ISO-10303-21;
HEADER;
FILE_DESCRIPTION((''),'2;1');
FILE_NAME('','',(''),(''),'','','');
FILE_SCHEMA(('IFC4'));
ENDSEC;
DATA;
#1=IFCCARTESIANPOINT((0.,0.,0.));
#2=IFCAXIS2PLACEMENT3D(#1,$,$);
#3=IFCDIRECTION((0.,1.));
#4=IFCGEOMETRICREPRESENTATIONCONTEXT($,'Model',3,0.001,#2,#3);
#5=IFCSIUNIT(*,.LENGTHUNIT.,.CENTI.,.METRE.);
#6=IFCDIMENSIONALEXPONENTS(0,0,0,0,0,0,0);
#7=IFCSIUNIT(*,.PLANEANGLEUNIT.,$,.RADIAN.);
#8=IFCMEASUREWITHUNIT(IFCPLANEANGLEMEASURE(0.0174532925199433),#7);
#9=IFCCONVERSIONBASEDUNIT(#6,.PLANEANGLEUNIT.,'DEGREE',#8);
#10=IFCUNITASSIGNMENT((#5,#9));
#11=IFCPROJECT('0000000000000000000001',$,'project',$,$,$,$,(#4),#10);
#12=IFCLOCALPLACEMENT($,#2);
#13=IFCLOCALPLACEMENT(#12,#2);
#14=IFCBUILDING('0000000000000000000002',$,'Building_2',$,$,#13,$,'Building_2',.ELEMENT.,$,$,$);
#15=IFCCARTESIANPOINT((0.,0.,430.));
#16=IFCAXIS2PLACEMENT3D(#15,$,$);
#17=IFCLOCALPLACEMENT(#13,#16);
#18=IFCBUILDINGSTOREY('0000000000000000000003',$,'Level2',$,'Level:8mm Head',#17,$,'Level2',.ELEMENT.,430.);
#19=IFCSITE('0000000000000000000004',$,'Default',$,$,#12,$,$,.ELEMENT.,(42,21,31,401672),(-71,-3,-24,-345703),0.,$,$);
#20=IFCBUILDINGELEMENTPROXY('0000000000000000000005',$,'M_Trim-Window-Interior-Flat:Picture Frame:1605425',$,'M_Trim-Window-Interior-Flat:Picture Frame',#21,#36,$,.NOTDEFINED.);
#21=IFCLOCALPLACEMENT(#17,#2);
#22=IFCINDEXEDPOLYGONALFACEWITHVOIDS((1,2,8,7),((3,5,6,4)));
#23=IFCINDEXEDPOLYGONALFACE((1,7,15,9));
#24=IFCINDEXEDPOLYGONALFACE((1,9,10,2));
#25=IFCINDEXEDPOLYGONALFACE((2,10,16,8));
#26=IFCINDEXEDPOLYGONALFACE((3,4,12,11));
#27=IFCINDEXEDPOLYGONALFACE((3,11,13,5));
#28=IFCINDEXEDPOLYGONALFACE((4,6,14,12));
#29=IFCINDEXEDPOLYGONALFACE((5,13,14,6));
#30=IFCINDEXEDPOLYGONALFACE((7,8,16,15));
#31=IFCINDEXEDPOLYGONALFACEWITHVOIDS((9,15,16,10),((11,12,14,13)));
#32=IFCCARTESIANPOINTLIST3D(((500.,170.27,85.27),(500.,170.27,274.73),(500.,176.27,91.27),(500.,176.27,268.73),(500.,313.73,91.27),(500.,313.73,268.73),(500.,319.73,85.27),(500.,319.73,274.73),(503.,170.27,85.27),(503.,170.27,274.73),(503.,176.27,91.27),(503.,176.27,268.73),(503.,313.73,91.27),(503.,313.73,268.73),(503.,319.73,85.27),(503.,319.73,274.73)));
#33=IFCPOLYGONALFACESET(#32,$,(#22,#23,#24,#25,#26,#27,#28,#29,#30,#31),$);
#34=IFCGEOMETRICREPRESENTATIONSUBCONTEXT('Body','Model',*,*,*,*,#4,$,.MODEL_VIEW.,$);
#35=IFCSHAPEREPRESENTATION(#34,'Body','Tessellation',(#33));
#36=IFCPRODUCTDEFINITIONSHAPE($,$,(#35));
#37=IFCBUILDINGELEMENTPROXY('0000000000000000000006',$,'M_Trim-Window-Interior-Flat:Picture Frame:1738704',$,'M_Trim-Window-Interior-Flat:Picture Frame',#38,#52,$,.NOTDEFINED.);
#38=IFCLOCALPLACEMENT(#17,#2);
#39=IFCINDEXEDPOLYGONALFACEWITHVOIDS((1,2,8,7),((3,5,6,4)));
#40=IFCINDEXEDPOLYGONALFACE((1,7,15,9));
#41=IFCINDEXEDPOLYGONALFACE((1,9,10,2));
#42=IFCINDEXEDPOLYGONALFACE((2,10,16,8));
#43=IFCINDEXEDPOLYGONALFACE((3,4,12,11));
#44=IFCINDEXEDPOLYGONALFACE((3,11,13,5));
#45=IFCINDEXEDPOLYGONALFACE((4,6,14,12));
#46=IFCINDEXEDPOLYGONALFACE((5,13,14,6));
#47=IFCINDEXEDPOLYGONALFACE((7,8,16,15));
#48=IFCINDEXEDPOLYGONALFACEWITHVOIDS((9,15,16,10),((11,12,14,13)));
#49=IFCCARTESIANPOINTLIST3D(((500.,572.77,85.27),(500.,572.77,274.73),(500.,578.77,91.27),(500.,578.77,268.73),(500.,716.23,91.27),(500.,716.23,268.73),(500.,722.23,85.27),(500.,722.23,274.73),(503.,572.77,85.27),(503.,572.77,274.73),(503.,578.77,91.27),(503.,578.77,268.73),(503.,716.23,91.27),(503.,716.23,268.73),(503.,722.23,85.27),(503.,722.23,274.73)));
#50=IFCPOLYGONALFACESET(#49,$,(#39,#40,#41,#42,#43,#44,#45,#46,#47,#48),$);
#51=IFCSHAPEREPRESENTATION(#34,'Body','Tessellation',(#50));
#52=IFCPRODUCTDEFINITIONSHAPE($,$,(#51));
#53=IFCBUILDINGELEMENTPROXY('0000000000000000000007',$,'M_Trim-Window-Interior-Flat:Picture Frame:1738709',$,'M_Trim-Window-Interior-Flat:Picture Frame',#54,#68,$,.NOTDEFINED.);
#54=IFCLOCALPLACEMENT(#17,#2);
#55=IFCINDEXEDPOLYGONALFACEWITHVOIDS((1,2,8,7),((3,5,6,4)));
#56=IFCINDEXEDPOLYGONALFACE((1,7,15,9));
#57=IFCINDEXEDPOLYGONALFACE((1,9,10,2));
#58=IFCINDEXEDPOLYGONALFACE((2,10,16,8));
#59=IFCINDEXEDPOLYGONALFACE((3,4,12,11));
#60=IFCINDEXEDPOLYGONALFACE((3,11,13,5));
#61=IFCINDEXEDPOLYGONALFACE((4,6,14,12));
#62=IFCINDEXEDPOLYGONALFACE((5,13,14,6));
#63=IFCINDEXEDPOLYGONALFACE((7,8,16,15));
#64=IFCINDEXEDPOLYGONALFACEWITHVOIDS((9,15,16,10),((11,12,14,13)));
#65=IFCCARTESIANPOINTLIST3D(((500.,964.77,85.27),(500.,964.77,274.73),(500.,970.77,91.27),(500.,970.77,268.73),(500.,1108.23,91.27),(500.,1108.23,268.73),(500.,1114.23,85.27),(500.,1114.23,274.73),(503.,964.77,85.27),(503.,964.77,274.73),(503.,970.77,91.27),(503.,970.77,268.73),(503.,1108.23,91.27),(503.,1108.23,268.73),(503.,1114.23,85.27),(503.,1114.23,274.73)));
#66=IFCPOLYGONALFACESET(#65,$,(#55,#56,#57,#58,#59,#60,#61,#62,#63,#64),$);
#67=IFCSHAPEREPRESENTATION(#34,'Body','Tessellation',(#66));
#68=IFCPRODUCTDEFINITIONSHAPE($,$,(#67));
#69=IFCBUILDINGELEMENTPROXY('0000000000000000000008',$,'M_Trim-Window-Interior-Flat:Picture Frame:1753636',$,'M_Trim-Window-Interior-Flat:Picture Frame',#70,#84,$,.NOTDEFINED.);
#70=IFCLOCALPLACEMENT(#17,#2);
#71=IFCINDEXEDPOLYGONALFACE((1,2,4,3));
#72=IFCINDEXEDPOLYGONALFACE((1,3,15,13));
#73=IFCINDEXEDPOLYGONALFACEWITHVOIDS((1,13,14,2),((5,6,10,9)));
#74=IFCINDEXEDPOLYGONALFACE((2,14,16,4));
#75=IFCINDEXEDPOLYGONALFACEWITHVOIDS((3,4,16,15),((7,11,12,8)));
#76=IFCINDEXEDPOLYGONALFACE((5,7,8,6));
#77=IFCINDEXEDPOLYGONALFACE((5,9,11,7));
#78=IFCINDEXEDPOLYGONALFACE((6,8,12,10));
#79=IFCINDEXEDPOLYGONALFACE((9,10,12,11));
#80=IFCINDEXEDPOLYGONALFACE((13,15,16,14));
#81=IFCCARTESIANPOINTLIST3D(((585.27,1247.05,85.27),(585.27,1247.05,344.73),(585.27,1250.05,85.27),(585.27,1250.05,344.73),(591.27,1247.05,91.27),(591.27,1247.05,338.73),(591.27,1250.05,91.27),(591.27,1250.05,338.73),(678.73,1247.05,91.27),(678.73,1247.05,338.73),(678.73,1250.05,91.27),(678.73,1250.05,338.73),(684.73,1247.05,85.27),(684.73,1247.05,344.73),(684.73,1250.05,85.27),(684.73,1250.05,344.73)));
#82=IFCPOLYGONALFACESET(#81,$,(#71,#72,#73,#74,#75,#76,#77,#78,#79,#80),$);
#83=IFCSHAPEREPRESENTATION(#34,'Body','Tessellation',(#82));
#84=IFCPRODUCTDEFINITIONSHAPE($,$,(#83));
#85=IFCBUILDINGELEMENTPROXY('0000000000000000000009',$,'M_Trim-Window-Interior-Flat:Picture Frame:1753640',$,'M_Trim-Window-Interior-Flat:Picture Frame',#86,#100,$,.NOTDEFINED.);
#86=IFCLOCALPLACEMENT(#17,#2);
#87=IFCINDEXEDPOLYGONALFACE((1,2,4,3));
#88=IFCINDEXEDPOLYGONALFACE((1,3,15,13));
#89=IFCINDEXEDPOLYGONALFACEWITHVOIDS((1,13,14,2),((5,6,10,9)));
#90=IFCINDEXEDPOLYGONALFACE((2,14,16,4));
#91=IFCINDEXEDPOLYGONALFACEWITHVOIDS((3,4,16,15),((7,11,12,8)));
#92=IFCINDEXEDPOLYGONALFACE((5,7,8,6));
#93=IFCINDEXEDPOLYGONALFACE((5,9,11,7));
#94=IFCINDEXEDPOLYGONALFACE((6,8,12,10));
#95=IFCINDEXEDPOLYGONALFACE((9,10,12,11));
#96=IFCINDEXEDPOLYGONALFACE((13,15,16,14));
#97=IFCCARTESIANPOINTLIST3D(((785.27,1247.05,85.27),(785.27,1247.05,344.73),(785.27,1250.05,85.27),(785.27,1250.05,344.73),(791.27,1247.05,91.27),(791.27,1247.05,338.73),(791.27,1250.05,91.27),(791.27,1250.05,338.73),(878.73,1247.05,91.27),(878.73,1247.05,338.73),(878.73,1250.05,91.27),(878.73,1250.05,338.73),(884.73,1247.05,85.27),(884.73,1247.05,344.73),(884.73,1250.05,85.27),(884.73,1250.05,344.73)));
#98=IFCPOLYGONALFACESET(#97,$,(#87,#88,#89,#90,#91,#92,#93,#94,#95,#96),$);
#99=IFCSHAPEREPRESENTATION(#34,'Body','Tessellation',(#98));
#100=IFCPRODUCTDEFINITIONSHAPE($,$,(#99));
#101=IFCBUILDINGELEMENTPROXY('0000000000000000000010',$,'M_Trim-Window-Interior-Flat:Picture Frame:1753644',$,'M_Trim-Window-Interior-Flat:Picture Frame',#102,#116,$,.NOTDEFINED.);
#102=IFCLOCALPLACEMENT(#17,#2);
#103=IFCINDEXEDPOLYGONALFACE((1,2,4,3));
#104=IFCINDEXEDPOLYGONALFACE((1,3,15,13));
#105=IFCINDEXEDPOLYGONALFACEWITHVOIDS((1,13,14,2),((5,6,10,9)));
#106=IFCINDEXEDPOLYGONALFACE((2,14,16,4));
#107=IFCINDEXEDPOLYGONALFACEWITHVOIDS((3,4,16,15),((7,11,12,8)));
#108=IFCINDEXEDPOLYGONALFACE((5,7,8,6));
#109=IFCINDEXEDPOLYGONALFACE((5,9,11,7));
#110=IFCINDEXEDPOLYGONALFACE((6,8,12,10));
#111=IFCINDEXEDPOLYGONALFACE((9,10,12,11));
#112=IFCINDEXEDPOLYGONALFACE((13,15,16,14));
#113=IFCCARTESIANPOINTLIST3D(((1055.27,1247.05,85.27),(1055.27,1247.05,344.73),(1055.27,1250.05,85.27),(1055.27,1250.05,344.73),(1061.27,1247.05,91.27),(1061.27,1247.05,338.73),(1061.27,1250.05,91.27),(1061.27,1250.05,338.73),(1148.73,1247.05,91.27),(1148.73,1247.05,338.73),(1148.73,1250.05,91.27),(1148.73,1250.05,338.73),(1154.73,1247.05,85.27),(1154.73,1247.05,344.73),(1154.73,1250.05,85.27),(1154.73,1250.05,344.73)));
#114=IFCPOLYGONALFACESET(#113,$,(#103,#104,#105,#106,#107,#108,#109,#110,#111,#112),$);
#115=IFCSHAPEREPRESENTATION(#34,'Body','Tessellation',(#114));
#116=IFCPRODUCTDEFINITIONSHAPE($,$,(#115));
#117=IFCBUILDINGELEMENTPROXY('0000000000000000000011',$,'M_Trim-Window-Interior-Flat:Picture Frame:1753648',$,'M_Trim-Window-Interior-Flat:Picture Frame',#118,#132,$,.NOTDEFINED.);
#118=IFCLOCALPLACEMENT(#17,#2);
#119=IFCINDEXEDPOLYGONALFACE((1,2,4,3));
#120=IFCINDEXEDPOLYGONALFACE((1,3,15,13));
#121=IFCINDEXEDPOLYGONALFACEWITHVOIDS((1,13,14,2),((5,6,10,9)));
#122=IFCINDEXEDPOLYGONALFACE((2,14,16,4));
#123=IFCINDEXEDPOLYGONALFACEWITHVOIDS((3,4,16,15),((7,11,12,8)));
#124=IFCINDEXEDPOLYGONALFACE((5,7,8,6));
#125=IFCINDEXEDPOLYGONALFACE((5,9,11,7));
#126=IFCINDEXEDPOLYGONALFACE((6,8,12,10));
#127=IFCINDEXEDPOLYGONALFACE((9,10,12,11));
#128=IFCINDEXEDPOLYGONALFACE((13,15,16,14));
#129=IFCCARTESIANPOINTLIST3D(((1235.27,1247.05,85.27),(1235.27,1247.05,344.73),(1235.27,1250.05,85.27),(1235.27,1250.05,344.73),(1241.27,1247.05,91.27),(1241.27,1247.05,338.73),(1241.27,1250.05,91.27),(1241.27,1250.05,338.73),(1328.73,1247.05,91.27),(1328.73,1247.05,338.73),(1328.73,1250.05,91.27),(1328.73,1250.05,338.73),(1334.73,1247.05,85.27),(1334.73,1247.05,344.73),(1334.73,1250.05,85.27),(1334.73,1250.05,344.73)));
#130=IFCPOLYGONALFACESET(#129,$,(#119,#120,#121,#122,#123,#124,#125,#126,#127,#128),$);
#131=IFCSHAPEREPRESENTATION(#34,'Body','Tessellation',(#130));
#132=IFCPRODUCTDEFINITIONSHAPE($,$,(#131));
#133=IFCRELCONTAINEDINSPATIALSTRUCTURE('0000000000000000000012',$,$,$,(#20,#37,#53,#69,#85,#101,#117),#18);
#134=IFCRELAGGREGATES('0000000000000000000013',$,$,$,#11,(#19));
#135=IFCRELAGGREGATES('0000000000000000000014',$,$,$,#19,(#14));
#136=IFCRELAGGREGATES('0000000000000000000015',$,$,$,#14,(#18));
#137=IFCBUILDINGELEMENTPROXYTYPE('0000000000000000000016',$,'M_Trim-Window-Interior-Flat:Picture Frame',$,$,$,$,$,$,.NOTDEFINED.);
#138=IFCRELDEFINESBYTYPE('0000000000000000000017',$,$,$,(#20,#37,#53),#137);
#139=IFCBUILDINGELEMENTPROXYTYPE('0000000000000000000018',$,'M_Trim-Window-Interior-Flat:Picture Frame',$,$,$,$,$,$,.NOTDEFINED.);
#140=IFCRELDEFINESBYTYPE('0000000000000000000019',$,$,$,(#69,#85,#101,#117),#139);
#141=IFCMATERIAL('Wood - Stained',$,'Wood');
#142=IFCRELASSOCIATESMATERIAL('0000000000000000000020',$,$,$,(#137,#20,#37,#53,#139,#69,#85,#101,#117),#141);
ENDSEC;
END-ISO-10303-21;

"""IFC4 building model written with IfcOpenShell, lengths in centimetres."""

from ifc_helpers import new_model, entity, si_unit, converted_unit, direction, frame, origin, place, context, subcontext, project, spatial, indexed_curve, outline, extrude, source, transform, mapped, material, type_object, type_shapes, element, save


model = new_model("IFC4")

# Units and contexts
model_context = context("Model", 3, precision=0.001, world=origin(), true_north=direction((0.0, 1.0)))
body_context = subcontext(model_context, "Body", "Model", "MODEL_VIEW")
ifc_project = project(units=[si_unit("LENGTHUNIT", "METRE", prefix="CENTI"), converted_unit("PLANEANGLEUNIT", "DEGREE", entity("IfcPlaneAngleMeasure", 0.0174532925199433), si_unit("PLANEANGLEUNIT", "RADIAN"), dimensions=[0, 0, 0, 0, 0, 0, 0])], contexts=[model_context])

# Site, building, storey
site_placement = place(None, origin())
site = spatial("IfcSite", under=ifc_project, at=site_placement, Name="Default", CompositionType="ELEMENT", RefLatitude=(42, 21, 31, 401672), RefLongitude=(-71, -3, -24, -345703), RefElevation=0.0)
building_placement = place(site_placement, origin())
building = spatial("IfcBuilding", under=site, at=building_placement, Name="Building_2", LongName="Building_2", CompositionType="ELEMENT")
storey_placement = place(building_placement, frame((0.0, 0.0, 430.0)))
storey = spatial("IfcBuildingStorey", under=building, at=storey_placement, Name="Level2", ObjectType="Level:8mm Head", LongName="Level2", CompositionType="ELEMENT", Elevation=430.0)

# Building element proxies
ifc_material_1 = material(Name="Wood - Stained", Category="Wood")
building_element_proxy_type_1 = type_object("IfcBuildingElementProxyType", Name="M_Trim-Window-Interior-Flat:Picture Frame", PredefinedType="NOTDEFINED", material=ifc_material_1)
shared_shape_1 = source(origin(), body_context, "Body", "SweptSolid", [
    extrude(outline(indexed_curve([(-94.73, -74.73), (94.73, -74.73), (94.73, 74.73), (-94.73, 74.73), (-94.73, -74.73)], self_intersect=False), holes=[indexed_curve([(-88.73, -68.73), (-88.73, 68.73), (88.73, 68.73), (88.73, -68.73), (-88.73, -68.73)], self_intersect=False)]), frame((0.0, 90.0, 0.0), z_axis=(0.0, 0.0, 1.0), x_axis=(0.0, 1.0, 0.0)), (0.0, 0.0, 1.0), 3.0),
])
type_shapes(building_element_proxy_type_1, [shared_shape_1])
for number, where, z_axis, x_axis, name in (
    (1, (500.0, 245.0, 270.0), (1.0, 0.0, 0.0), (0.0, -1.0, 0.0), "M_Trim-Window-Interior-Flat:Picture Frame:1605425"),
    (2, (500.0, 647.5, 270.0), (1.0, 0.0, 0.0), (0.0, -1.0, 0.0), "M_Trim-Window-Interior-Flat:Picture Frame:1738704"),
    (3, (500.0, 1039.5, 270.0), (1.0, 0.0, 0.0), (0.0, -1.0, 0.0), "M_Trim-Window-Interior-Flat:Picture Frame:1738709"),
):
    element("IfcBuildingElementProxy", number, at=place(storey_placement, frame(where, z_axis=z_axis, x_axis=x_axis)), inside=storey, type_object=building_element_proxy_type_1, material=ifc_material_1, Name=name, ObjectType="M_Trim-Window-Interior-Flat:Picture Frame", PredefinedType="NOTDEFINED", context=body_context, shape_type="MappedRepresentation", body=[
        mapped(shared_shape_1, transform((0.0, 0.0, 0.0), scale=1.0)),
    ])
building_element_proxy_type_2 = type_object("IfcBuildingElementProxyType", Name="M_Trim-Window-Interior-Flat:Picture Frame", PredefinedType="NOTDEFINED", material=ifc_material_1)
shared_shape_2 = source(origin(), body_context, "Body", "SweptSolid", [
    extrude(outline(indexed_curve([(-49.73, -129.73), (49.73, -129.73), (49.73, 129.73), (-49.73, 129.73), (-49.73, -129.73)], self_intersect=False), holes=[indexed_curve([(-43.73, -123.73), (-43.73, 123.73), (43.73, 123.73), (43.73, -123.73), (-43.73, -123.73)], self_intersect=False)]), frame((0.0, -125.0, 0.0), z_axis=(0.0, 0.0, 1.0), x_axis=(-1.0, 0.0, 0.0)), (0.0, 0.0, 1.0), 3.0),
])
type_shapes(building_element_proxy_type_2, [shared_shape_2])
for number, where, z_axis, x_axis, name in (
    (4, (635.0, 1250.05, 340.0), (0.0, -1.0, 0.0), (1.0, 0.0, 0.0), "M_Trim-Window-Interior-Flat:Picture Frame:1753636"),
    (5, (835.0, 1250.05, 340.0), (0.0, -1.0, 0.0), (1.0, 0.0, 0.0), "M_Trim-Window-Interior-Flat:Picture Frame:1753640"),
    (6, (1105.0, 1250.05, 340.0), (0.0, -1.0, 0.0), (1.0, 0.0, 0.0), "M_Trim-Window-Interior-Flat:Picture Frame:1753644"),
    (7, (1285.0, 1250.05, 340.0), (0.0, -1.0, 0.0), (1.0, 0.0, 0.0), "M_Trim-Window-Interior-Flat:Picture Frame:1753648"),
):
    element("IfcBuildingElementProxy", number, at=place(storey_placement, frame(where, z_axis=z_axis, x_axis=x_axis)), inside=storey, type_object=building_element_proxy_type_2, material=ifc_material_1, Name=name, ObjectType="M_Trim-Window-Interior-Flat:Picture Frame", PredefinedType="NOTDEFINED", context=body_context, shape_type="MappedRepresentation", body=[
        mapped(shared_shape_2, transform((0.0, 0.0, 0.0), scale=1.0)),
    ])

save(model, "model.ifc")
